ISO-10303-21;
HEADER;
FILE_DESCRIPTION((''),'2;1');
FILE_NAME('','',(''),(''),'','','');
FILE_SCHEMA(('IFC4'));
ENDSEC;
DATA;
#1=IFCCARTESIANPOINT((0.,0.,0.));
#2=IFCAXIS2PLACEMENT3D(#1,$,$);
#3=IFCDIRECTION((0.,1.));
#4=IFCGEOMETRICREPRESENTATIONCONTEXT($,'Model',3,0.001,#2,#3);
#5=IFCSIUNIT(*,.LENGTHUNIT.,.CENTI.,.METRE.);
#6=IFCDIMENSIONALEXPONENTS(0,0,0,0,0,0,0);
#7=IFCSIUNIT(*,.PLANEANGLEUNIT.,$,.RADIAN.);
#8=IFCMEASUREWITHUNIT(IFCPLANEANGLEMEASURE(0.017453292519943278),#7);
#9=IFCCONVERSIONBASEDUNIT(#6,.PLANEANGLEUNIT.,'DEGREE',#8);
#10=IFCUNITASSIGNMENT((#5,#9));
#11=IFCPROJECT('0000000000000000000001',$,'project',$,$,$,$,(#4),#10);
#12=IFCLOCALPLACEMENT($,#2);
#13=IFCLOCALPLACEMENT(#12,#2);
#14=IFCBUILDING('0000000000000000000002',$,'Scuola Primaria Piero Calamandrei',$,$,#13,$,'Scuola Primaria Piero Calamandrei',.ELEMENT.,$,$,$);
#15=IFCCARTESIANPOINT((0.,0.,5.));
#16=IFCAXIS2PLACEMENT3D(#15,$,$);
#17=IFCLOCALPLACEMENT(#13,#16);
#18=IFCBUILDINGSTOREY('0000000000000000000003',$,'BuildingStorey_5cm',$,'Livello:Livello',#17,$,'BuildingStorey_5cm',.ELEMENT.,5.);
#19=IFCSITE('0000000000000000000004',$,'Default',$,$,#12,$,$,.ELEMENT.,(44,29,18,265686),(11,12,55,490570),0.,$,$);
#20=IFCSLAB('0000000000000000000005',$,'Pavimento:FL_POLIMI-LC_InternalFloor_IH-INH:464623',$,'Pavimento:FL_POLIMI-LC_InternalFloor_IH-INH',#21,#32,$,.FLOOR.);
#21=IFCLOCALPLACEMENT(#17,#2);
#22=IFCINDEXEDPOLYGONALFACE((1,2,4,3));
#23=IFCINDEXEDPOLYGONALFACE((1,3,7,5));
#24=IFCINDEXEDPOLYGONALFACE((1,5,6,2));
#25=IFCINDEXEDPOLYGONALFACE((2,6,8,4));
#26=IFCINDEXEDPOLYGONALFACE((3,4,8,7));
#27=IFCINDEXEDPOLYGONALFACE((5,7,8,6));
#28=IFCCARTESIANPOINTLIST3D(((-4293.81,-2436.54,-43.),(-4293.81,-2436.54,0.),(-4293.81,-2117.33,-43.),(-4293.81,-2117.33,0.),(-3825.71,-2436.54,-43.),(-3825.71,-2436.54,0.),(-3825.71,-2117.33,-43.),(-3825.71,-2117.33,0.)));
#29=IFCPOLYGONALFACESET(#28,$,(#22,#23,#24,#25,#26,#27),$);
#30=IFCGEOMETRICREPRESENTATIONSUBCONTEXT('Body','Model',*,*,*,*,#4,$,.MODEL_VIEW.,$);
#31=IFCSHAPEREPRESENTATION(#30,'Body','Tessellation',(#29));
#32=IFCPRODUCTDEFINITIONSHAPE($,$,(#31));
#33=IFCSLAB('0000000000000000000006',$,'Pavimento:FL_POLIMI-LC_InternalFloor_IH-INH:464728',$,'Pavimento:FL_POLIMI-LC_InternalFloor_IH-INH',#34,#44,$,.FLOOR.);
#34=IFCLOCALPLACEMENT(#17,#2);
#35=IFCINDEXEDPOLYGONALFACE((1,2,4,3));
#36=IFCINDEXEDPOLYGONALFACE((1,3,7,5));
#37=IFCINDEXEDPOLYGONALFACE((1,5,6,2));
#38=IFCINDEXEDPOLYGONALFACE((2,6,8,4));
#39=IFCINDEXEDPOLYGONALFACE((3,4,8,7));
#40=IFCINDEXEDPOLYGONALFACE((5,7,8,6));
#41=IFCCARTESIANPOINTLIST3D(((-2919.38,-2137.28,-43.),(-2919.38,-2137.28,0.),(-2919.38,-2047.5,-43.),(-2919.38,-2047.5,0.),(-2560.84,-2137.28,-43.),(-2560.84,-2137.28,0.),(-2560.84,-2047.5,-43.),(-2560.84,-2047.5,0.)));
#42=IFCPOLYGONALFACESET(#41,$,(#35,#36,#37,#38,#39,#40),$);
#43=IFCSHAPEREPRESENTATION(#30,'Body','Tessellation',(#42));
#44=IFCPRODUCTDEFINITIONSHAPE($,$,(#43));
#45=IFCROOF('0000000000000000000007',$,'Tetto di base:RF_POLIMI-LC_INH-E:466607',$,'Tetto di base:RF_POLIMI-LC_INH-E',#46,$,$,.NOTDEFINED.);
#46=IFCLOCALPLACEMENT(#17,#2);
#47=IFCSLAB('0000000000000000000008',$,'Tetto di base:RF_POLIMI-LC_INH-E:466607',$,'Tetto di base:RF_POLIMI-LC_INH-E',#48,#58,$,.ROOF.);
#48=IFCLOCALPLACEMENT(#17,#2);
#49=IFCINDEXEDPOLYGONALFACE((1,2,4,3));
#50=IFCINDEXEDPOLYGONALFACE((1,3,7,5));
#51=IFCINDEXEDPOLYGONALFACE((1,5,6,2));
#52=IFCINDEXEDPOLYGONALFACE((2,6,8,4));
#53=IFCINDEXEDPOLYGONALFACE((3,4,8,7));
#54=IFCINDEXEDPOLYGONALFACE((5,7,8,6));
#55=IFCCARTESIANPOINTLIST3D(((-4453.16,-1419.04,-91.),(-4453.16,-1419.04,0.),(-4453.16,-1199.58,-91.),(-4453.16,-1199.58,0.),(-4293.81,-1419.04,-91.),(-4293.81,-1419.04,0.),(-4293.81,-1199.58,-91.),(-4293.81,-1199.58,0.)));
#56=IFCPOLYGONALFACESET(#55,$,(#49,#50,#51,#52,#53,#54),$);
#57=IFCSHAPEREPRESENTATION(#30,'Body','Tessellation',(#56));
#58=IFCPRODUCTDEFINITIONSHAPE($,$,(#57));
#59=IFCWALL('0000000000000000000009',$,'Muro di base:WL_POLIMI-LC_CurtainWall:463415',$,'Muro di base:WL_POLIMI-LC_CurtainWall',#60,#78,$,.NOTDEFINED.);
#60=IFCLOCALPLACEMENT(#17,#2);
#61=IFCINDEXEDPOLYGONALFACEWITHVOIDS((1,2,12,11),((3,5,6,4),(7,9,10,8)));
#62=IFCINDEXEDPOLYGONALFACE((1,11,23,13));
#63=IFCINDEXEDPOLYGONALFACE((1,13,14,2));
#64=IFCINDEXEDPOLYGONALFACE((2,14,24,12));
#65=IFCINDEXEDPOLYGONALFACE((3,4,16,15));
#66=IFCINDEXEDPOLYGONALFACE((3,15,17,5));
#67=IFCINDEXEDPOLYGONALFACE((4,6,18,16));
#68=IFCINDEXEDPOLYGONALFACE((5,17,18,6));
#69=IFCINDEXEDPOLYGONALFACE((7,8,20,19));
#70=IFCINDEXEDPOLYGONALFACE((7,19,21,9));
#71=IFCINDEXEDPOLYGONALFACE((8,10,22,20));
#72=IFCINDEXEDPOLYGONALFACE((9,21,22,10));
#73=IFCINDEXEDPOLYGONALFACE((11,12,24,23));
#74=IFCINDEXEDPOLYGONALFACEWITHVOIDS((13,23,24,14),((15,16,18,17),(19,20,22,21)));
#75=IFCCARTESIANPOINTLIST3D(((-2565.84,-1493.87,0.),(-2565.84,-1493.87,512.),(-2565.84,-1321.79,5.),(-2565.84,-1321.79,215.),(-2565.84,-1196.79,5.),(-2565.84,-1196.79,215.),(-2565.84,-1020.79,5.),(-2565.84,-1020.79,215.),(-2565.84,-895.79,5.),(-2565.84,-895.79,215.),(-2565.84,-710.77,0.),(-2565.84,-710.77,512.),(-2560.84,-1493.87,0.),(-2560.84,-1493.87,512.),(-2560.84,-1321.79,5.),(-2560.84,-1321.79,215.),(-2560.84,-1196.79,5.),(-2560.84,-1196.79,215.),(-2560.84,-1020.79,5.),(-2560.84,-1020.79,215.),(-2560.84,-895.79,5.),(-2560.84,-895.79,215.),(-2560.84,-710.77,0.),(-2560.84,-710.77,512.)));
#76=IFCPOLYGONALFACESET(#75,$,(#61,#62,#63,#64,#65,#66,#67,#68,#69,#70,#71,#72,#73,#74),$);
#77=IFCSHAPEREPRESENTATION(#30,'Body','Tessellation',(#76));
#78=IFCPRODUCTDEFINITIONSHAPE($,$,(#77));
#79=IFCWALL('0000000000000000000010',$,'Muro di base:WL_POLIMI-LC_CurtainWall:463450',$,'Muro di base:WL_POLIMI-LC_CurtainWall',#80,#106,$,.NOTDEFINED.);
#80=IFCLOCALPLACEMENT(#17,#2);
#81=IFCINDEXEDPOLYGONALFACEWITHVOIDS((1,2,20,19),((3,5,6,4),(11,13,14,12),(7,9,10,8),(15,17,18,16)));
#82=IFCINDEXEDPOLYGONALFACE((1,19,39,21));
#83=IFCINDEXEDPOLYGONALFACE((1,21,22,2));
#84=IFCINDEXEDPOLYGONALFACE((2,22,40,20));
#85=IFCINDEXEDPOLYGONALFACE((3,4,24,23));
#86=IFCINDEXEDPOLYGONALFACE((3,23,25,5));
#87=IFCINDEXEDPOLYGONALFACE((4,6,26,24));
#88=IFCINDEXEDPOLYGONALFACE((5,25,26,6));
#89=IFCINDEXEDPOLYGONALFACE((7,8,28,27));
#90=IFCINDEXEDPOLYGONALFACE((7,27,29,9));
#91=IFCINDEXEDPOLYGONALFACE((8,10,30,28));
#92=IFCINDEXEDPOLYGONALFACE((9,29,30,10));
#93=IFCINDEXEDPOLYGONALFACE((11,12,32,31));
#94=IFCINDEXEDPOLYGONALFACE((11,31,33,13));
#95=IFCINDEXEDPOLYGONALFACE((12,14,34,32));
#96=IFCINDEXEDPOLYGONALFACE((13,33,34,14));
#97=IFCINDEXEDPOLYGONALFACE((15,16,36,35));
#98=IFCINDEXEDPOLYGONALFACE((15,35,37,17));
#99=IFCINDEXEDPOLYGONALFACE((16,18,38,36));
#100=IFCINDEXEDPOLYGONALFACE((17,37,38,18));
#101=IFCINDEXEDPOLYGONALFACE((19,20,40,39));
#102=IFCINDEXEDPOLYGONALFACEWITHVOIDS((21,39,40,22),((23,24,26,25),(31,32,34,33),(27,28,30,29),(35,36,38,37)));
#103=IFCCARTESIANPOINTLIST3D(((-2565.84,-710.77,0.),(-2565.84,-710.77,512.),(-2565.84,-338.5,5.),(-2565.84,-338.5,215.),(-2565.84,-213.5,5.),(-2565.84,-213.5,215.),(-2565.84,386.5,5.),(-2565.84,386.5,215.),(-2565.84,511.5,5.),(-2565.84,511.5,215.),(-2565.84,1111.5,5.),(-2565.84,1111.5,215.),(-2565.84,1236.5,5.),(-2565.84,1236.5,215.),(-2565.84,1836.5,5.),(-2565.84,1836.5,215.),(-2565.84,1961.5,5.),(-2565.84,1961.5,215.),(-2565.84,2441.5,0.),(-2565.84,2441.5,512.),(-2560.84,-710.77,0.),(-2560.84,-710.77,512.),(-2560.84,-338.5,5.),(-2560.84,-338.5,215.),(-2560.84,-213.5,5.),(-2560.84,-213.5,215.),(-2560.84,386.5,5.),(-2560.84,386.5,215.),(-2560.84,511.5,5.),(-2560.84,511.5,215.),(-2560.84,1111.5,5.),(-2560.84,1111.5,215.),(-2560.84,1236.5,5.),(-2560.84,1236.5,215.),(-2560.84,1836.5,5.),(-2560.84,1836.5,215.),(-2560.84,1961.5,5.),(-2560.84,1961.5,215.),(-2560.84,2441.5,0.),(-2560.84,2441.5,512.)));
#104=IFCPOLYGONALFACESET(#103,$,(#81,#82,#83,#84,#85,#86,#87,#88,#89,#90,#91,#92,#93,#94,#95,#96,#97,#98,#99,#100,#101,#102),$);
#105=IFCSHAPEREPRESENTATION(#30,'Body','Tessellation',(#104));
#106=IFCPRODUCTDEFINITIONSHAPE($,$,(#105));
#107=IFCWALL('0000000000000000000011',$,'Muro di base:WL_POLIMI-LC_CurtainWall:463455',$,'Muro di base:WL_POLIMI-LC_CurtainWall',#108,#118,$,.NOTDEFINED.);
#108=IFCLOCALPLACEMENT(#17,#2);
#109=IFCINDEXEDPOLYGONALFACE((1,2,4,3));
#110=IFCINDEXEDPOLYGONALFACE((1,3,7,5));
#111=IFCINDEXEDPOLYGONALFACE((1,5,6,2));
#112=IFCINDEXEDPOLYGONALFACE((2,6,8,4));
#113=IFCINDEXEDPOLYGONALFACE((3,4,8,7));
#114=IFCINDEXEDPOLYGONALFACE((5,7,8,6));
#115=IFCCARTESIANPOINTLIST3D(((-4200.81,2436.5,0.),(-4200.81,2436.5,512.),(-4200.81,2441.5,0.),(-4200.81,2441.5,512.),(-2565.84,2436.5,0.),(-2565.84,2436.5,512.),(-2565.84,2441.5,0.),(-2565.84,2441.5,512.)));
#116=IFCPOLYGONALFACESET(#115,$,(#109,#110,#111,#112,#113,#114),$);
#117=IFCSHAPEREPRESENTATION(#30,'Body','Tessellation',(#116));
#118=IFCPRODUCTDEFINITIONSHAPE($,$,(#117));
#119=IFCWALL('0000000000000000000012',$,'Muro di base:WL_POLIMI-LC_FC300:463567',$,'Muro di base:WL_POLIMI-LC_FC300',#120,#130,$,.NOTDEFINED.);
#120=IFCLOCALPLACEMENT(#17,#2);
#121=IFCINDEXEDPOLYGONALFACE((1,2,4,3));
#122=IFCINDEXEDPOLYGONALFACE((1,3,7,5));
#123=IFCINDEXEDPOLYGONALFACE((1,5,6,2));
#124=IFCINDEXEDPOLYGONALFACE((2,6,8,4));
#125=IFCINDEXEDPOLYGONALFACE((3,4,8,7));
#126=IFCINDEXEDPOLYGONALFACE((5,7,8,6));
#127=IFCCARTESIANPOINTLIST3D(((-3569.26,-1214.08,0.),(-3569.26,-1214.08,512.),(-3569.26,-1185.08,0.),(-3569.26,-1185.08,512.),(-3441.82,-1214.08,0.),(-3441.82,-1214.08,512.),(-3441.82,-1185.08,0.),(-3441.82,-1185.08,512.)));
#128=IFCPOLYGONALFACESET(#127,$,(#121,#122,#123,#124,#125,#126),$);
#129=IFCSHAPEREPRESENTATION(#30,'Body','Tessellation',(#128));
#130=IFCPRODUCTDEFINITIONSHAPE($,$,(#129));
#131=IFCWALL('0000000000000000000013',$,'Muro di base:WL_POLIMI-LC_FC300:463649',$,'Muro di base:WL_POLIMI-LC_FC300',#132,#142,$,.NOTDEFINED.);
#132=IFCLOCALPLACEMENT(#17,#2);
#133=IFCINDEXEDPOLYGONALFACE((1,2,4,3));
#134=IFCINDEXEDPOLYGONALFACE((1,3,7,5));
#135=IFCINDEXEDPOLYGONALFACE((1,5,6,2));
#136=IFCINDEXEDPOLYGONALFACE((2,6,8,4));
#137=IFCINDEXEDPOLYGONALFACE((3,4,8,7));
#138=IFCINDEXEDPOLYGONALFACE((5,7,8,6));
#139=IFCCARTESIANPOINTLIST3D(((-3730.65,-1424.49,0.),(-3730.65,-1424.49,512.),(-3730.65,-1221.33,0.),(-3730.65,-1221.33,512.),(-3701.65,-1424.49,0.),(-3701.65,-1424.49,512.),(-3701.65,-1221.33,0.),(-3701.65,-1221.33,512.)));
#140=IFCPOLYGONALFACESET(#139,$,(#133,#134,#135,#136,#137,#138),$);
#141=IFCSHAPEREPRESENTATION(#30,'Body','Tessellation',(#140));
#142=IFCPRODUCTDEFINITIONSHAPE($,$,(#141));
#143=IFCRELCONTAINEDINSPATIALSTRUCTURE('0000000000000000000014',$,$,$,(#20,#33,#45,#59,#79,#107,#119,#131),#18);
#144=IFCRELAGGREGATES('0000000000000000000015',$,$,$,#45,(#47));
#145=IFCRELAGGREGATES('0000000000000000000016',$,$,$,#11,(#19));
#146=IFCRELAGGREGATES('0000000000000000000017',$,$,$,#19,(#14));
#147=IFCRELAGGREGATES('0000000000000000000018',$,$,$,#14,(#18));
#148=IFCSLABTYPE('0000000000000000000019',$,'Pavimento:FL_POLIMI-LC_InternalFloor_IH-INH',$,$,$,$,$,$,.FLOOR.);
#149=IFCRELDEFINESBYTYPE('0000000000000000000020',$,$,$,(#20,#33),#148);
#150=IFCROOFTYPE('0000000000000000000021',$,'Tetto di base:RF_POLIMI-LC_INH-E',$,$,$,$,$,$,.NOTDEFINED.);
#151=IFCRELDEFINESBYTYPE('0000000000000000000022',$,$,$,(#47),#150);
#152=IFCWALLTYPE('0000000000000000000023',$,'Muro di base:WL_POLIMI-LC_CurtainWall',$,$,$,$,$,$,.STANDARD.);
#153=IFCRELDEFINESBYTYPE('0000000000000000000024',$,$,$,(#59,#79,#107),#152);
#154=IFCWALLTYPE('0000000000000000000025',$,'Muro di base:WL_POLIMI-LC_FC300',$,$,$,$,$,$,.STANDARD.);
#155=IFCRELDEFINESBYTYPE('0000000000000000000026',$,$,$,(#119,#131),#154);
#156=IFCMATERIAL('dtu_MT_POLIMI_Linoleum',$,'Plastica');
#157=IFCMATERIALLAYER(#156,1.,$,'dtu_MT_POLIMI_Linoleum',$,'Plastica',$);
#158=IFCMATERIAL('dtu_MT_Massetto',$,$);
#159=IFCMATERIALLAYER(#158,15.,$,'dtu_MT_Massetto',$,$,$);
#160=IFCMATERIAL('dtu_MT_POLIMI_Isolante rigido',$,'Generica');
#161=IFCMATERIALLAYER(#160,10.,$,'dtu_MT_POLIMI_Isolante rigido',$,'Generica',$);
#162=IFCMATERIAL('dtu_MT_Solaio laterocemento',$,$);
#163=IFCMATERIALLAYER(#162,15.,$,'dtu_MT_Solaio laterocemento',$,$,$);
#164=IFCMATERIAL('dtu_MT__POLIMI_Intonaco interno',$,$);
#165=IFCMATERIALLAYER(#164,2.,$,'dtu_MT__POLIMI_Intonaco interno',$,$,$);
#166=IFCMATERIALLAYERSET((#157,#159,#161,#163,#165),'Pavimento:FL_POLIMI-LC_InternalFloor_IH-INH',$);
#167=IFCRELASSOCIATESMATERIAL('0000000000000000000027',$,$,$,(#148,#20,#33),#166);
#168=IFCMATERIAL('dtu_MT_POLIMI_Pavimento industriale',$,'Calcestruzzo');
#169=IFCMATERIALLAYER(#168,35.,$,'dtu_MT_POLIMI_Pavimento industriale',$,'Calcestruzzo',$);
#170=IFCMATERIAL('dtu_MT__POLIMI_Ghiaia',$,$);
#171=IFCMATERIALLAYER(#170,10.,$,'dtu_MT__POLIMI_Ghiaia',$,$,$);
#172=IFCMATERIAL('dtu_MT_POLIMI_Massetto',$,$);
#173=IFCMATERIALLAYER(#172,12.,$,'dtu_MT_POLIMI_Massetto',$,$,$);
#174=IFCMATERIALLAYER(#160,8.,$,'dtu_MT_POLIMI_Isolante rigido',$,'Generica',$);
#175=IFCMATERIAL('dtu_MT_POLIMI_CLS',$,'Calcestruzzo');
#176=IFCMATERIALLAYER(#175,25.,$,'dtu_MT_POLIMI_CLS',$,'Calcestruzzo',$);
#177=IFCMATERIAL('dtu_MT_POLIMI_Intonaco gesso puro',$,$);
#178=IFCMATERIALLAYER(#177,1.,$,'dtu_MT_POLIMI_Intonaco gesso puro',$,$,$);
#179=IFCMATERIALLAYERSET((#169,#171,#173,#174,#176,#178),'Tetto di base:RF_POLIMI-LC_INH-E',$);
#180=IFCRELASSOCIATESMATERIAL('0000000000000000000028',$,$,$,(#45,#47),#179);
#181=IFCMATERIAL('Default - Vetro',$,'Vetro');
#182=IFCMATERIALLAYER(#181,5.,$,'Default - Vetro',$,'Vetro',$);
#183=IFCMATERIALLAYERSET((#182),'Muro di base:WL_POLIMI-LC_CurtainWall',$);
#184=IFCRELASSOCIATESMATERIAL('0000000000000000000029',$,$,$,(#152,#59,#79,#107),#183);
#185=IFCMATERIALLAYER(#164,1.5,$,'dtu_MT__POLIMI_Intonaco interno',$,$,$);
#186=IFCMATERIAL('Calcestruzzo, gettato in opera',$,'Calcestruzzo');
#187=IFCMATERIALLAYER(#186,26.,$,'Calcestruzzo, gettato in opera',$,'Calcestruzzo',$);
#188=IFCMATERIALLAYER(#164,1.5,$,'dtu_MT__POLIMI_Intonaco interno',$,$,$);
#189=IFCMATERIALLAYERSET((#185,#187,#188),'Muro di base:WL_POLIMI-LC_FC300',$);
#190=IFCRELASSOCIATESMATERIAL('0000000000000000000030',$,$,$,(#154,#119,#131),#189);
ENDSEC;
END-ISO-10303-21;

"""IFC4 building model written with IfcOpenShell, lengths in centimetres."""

from ifc_helpers import new_model, entity, si_unit, converted_unit, direction, frame, frame_2d, origin, origin_2d_with_axis, place, context, subcontext, project, spatial, rectangle, extrude, material, layer, layer_set, layer_usage, type_object, element, aggregate, save


model = new_model("IFC4")

# Units and contexts
model_context = context("Model", 3, precision=0.001, world=origin(), true_north=direction((0.0, 1.0)))
body_context = subcontext(model_context, "Body", "Model", "MODEL_VIEW")
ifc_project = project(units=[si_unit("LENGTHUNIT", "METRE", prefix="CENTI"), converted_unit("PLANEANGLEUNIT", "DEGREE", entity("IfcPlaneAngleMeasure", 0.017453292519943278), si_unit("PLANEANGLEUNIT", "RADIAN"), dimensions=[0, 0, 0, 0, 0, 0, 0])], contexts=[model_context])

# Site, building, storey
site_placement = place(None, origin())
site = spatial("IfcSite", under=ifc_project, at=site_placement, Name="Default", CompositionType="ELEMENT", RefLatitude=(44, 29, 18, 265686), RefLongitude=(11, 12, 55, 490570), RefElevation=0.0)
building_placement = place(site_placement, origin())
building = spatial("IfcBuilding", under=site, at=building_placement, Name="Scuola Primaria Piero Calamandrei", LongName="Scuola Primaria Piero Calamandrei", CompositionType="ELEMENT")
storey_placement = place(building_placement, frame((0.0, 0.0, 5.0)))
storey = spatial("IfcBuildingStorey", under=building, at=storey_placement, Name="BuildingStorey_5cm", ObjectType="Livello:Livello", LongName="BuildingStorey_5cm", CompositionType="ELEMENT", Elevation=5.0)

# Slabs
ifc_material_1 = material(Name="dtu_MT_POLIMI_Linoleum", Category="Plastica")
ifc_layer_1 = layer(ifc_material_1, 1.0, Name="dtu_MT_POLIMI_Linoleum", Category="Plastica")
ifc_material_2 = material(Name="dtu_MT_Massetto")
ifc_layer_2 = layer(ifc_material_2, 15.0, Name="dtu_MT_Massetto")
ifc_material_3 = material(Name="dtu_MT_POLIMI_Isolante rigido", Category="Generica")
ifc_layer_3 = layer(ifc_material_3, 10.0, Name="dtu_MT_POLIMI_Isolante rigido", Category="Generica")
ifc_material_4 = material(Name="dtu_MT_Solaio laterocemento")
ifc_layer_4 = layer(ifc_material_4, 15.0, Name="dtu_MT_Solaio laterocemento")
ifc_material_5 = material(Name="dtu_MT__POLIMI_Intonaco interno")
ifc_layer_5 = layer(ifc_material_5, 2.0, Name="dtu_MT__POLIMI_Intonaco interno")
ifc_layer_set_1 = layer_set([ifc_layer_1, ifc_layer_2, ifc_layer_3, ifc_layer_4, ifc_layer_5], Name="Pavimento:FL_POLIMI-LC_InternalFloor_IH-INH")
slab_type = type_object("IfcSlabType", Name="Pavimento:FL_POLIMI-LC_InternalFloor_IH-INH", PredefinedType="FLOOR", material=ifc_layer_set_1)
ifc_layer_usage_1 = layer_usage(ifc_layer_set_1, "AXIS3", "POSITIVE", 0.0)
slab_1_placement = place(storey_placement, origin())
element("IfcSlab", 1, at=slab_1_placement, inside=storey, type_object=slab_type, material=ifc_layer_usage_1, Name="Pavimento:FL_POLIMI-LC_InternalFloor_IH-INH:464623", ObjectType="Pavimento:FL_POLIMI-LC_InternalFloor_IH-INH", PredefinedType="FLOOR", context=body_context, shape_type="SweptSolid", body=[
    extrude(rectangle(XDim=319.22, YDim=468.1, at=frame_2d((0.0, 0.0), x_axis=(1.0, 0.0))), frame((-4059.76, -2276.94, 0.0), z_axis=(0.0, 0.0, -1.0), x_axis=(0.0, 1.0, 0.0)), (0.0, 0.0, 1.0), 43.0),
])
ifc_layer_usage_2 = layer_usage(ifc_layer_set_1, "AXIS3", "POSITIVE", 0.0)
slab_2_placement = place(storey_placement, origin())
element("IfcSlab", 2, at=slab_2_placement, inside=storey, type_object=slab_type, material=ifc_layer_usage_2, Name="Pavimento:FL_POLIMI-LC_InternalFloor_IH-INH:464728", ObjectType="Pavimento:FL_POLIMI-LC_InternalFloor_IH-INH", PredefinedType="FLOOR", context=body_context, shape_type="SweptSolid", body=[
    extrude(rectangle(XDim=89.78, YDim=358.55, at=origin_2d_with_axis()), frame((-2740.11, -2092.39, 0.0), z_axis=(0.0, 0.0, -1.0), x_axis=(0.0, 1.0, 0.0)), (0.0, 0.0, 1.0), 43.0),
])

# Roof, slab
ifc_material_6 = material(Name="dtu_MT_POLIMI_Pavimento industriale", Category="Calcestruzzo")
ifc_layer_6 = layer(ifc_material_6, 35.0, Name="dtu_MT_POLIMI_Pavimento industriale", Category="Calcestruzzo")
ifc_material_7 = material(Name="dtu_MT__POLIMI_Ghiaia")
ifc_layer_7 = layer(ifc_material_7, 10.0, Name="dtu_MT__POLIMI_Ghiaia")
ifc_material_8 = material(Name="dtu_MT_POLIMI_Massetto")
ifc_layer_8 = layer(ifc_material_8, 12.0, Name="dtu_MT_POLIMI_Massetto")
ifc_layer_9 = layer(ifc_material_3, 8.0, Name="dtu_MT_POLIMI_Isolante rigido", Category="Generica")
ifc_material_9 = material(Name="dtu_MT_POLIMI_CLS", Category="Calcestruzzo")
ifc_layer_10 = layer(ifc_material_9, 25.0, Name="dtu_MT_POLIMI_CLS", Category="Calcestruzzo")
ifc_material_10 = material(Name="dtu_MT_POLIMI_Intonaco gesso puro")
ifc_layer_11 = layer(ifc_material_10, 1.0, Name="dtu_MT_POLIMI_Intonaco gesso puro")
ifc_layer_set_2 = layer_set([ifc_layer_6, ifc_layer_7, ifc_layer_8, ifc_layer_9, ifc_layer_10, ifc_layer_11], Name="Tetto di base:RF_POLIMI-LC_INH-E")
roof_type = type_object("IfcRoofType", Name="Tetto di base:RF_POLIMI-LC_INH-E", PredefinedType="NOTDEFINED")
roof_1_placement = place(storey_placement, frame((-4453.16, -1419.04, -91.0)))
roof_1 = element("IfcRoof", 3, at=roof_1_placement, inside=storey, material=ifc_layer_set_2, Name="Tetto di base:RF_POLIMI-LC_INH-E:466607", ObjectType="Tetto di base:RF_POLIMI-LC_INH-E", PredefinedType="NOTDEFINED")
slab_3_placement = place(roof_1_placement, origin())
slab_3 = element("IfcSlab", 4, at=slab_3_placement, type_object=roof_type, material=ifc_layer_set_2, Name="Tetto di base:RF_POLIMI-LC_INH-E:466607", ObjectType="Tetto di base:RF_POLIMI-LC_INH-E", PredefinedType="ROOF", context=body_context, shape_type="SweptSolid", body=[
    extrude(rectangle(XDim=159.35, YDim=219.46, at=frame_2d((0.0, 0.0), x_axis=(-1.0, 0.0))), frame((79.68, 109.73, 0.0)), (0.0, 0.0, 1.0), 91.0),
])
aggregate(roof_1, [slab_3])

# Walls, openings
ifc_material_11 = material(Name="Default - Vetro", Category="Vetro")
ifc_layer_12 = layer(ifc_material_11, 5.0, Name="Default - Vetro", Category="Vetro")
ifc_layer_set_3 = layer_set([ifc_layer_12], Name="Muro di base:WL_POLIMI-LC_CurtainWall")
ifc_layer_usage_3 = layer_usage(ifc_layer_set_3, "AXIS2", "NEGATIVE", 2.5)
wall_type_1 = type_object("IfcWallType", Name="Muro di base:WL_POLIMI-LC_CurtainWall", PredefinedType="STANDARD", material=ifc_layer_set_3)
wall_1_placement = place(storey_placement, frame((-2563.34, -710.77, 0.0), z_axis=(0.0, 0.0, 1.0), x_axis=(0.0, -1.0, 0.0)))
wall_1 = element("IfcWall", 5, at=wall_1_placement, inside=storey, type_object=wall_type_1, material=ifc_layer_usage_3, Name="Muro di base:WL_POLIMI-LC_CurtainWall:463415", ObjectType="Muro di base:WL_POLIMI-LC_CurtainWall", PredefinedType="NOTDEFINED", context=body_context, shape_type="SweptSolid", body=[
    extrude(rectangle(XDim=783.09, YDim=5.0, at=frame_2d((391.55, 0.0), x_axis=(-1.0, 0.0))), origin(), (0.0, 0.0, 1.0), 512.0),
])
opening_1_placement = place(wall_1_placement, frame((486.02, -2.5, 5.0)))
element("IfcOpeningElement", 6, at=opening_1_placement, cuts=wall_1, PredefinedType="OPENING", context=body_context, shape_type="SweptSolid", body=[
    extrude(rectangle(XDim=210.0, YDim=125.0, at=frame_2d((105.0, 62.5), x_axis=(-1.0, 0.0))), frame((0.0, 0.0, 0.0), z_axis=(0.0, 1.0, 0.0), x_axis=(0.0, 0.0, 1.0)), (0.0, 0.0, 1.0), 5.0),
])
opening_2_placement = place(wall_1_placement, frame((185.02, -2.5, 5.0)))
element("IfcOpeningElement", 7, at=opening_2_placement, cuts=wall_1, PredefinedType="OPENING", context=body_context, shape_type="SweptSolid", body=[
    extrude(rectangle(XDim=210.0, YDim=125.0, at=frame_2d((105.0, 62.5), x_axis=(-1.0, 0.0))), frame((0.0, 0.0, 0.0), z_axis=(0.0, 1.0, 0.0), x_axis=(0.0, 0.0, 1.0)), (0.0, 0.0, 1.0), 5.0),
])
ifc_layer_usage_4 = layer_usage(ifc_layer_set_3, "AXIS2", "NEGATIVE", 2.5)
wall_2_placement = place(storey_placement, frame((-2563.34, 2441.5, 0.0), z_axis=(0.0, 0.0, 1.0), x_axis=(0.0, -1.0, 0.0)))
wall_2 = element("IfcWall", 8, at=wall_2_placement, inside=storey, type_object=wall_type_1, material=ifc_layer_usage_4, Name="Muro di base:WL_POLIMI-LC_CurtainWall:463450", ObjectType="Muro di base:WL_POLIMI-LC_CurtainWall", PredefinedType="NOTDEFINED", context=body_context, shape_type="SweptSolid", body=[
    extrude(rectangle(XDim=3152.28, YDim=5.0, at=frame_2d((1576.14, 0.0), x_axis=(-1.0, 0.0))), origin(), (0.0, 0.0, 1.0), 512.0),
])
opening_3_placement = place(wall_2_placement, frame((2655.0, -2.5, 5.0)))
element("IfcOpeningElement", 9, at=opening_3_placement, cuts=wall_2, PredefinedType="OPENING", context=body_context, shape_type="SweptSolid", body=[
    extrude(rectangle(XDim=210.0, YDim=125.0, at=frame_2d((105.0, 62.5), x_axis=(-1.0, 0.0))), frame((0.0, 0.0, 0.0), z_axis=(0.0, 1.0, 0.0), x_axis=(0.0, 0.0, 1.0)), (0.0, 0.0, 1.0), 5.0),
])
opening_4_placement = place(wall_2_placement, frame((1930.0, -2.5, 5.0)))
element("IfcOpeningElement", 10, at=opening_4_placement, cuts=wall_2, PredefinedType="OPENING", context=body_context, shape_type="SweptSolid", body=[
    extrude(rectangle(XDim=210.0, YDim=125.0, at=frame_2d((105.0, 62.5), x_axis=(-1.0, 0.0))), frame((0.0, 0.0, 0.0), z_axis=(0.0, 1.0, 0.0), x_axis=(0.0, 0.0, 1.0)), (0.0, 0.0, 1.0), 5.0),
])
opening_5_placement = place(wall_2_placement, frame((1205.0, -2.5, 5.0)))
element("IfcOpeningElement", 11, at=opening_5_placement, cuts=wall_2, PredefinedType="OPENING", context=body_context, shape_type="SweptSolid", body=[
    extrude(rectangle(XDim=210.0, YDim=125.0, at=frame_2d((105.0, 62.5), x_axis=(-1.0, 0.0))), frame((0.0, 0.0, 0.0), z_axis=(0.0, 1.0, 0.0), x_axis=(0.0, 0.0, 1.0)), (0.0, 0.0, 1.0), 5.0),
])
opening_6_placement = place(wall_2_placement, frame((480.0, -2.5, 5.0)))
element("IfcOpeningElement", 12, at=opening_6_placement, cuts=wall_2, PredefinedType="OPENING", context=body_context, shape_type="SweptSolid", body=[
    extrude(rectangle(XDim=210.0, YDim=125.0, at=frame_2d((105.0, 62.5), x_axis=(-1.0, 0.0))), frame((0.0, 0.0, 0.0), z_axis=(0.0, 1.0, 0.0), x_axis=(0.0, 0.0, 1.0)), (0.0, 0.0, 1.0), 5.0),
])

# Walls
ifc_layer_usage_5 = layer_usage(ifc_layer_set_3, "AXIS2", "NEGATIVE", 2.5)
wall_3_placement = place(storey_placement, frame((-4200.81, 2439.0, 0.0)))
element("IfcWall", 13, at=wall_3_placement, inside=storey, type_object=wall_type_1, material=ifc_layer_usage_5, Name="Muro di base:WL_POLIMI-LC_CurtainWall:463455", ObjectType="Muro di base:WL_POLIMI-LC_CurtainWall", PredefinedType="NOTDEFINED", context=body_context, shape_type="SweptSolid", body=[
    extrude(rectangle(XDim=1634.97, YDim=5.0, at=frame_2d((817.49, 0.0), x_axis=(-1.0, 0.0))), origin(), (0.0, 0.0, 1.0), 512.0),
])
ifc_layer_13 = layer(ifc_material_5, 1.5, Name="dtu_MT__POLIMI_Intonaco interno")
ifc_material_12 = material(Name="Calcestruzzo, gettato in opera", Category="Calcestruzzo")
ifc_layer_14 = layer(ifc_material_12, 26.0, Name="Calcestruzzo, gettato in opera", Category="Calcestruzzo")
ifc_layer_15 = layer(ifc_material_5, 1.5, Name="dtu_MT__POLIMI_Intonaco interno")
ifc_layer_set_4 = layer_set([ifc_layer_13, ifc_layer_14, ifc_layer_15], Name="Muro di base:WL_POLIMI-LC_FC300")
ifc_layer_usage_6 = layer_usage(ifc_layer_set_4, "AXIS2", "NEGATIVE", 14.5)
wall_type_2 = type_object("IfcWallType", Name="Muro di base:WL_POLIMI-LC_FC300", PredefinedType="STANDARD", material=ifc_layer_set_4)
wall_4_placement = place(storey_placement, frame((-3441.82, -1199.58, 0.0), z_axis=(0.0, 0.0, 1.0), x_axis=(-1.0, 0.0, 0.0)))
element("IfcWall", 14, at=wall_4_placement, inside=storey, type_object=wall_type_2, material=ifc_layer_usage_6, Name="Muro di base:WL_POLIMI-LC_FC300:463567", ObjectType="Muro di base:WL_POLIMI-LC_FC300", PredefinedType="NOTDEFINED", context=body_context, shape_type="SweptSolid", body=[
    extrude(rectangle(XDim=127.43, YDim=29.0, at=frame_2d((63.72, 0.0), x_axis=(-1.0, 0.0))), origin(), (0.0, 0.0, 1.0), 512.0),
])
ifc_layer_usage_7 = layer_usage(ifc_layer_set_4, "AXIS2", "NEGATIVE", 14.5)
wall_5_placement = place(storey_placement, frame((-3716.15, -1221.33, 0.0), z_axis=(0.0, 0.0, 1.0), x_axis=(0.0, -1.0, 0.0)))
element("IfcWall", 15, at=wall_5_placement, inside=storey, type_object=wall_type_2, material=ifc_layer_usage_7, Name="Muro di base:WL_POLIMI-LC_FC300:463649", ObjectType="Muro di base:WL_POLIMI-LC_FC300", PredefinedType="NOTDEFINED", context=body_context, shape_type="SweptSolid", body=[
    extrude(rectangle(XDim=203.16, YDim=29.0, at=frame_2d((101.58, 0.0), x_axis=(-1.0, 0.0))), origin(), (0.0, 0.0, 1.0), 512.0),
])

save(model, "model.ifc")
